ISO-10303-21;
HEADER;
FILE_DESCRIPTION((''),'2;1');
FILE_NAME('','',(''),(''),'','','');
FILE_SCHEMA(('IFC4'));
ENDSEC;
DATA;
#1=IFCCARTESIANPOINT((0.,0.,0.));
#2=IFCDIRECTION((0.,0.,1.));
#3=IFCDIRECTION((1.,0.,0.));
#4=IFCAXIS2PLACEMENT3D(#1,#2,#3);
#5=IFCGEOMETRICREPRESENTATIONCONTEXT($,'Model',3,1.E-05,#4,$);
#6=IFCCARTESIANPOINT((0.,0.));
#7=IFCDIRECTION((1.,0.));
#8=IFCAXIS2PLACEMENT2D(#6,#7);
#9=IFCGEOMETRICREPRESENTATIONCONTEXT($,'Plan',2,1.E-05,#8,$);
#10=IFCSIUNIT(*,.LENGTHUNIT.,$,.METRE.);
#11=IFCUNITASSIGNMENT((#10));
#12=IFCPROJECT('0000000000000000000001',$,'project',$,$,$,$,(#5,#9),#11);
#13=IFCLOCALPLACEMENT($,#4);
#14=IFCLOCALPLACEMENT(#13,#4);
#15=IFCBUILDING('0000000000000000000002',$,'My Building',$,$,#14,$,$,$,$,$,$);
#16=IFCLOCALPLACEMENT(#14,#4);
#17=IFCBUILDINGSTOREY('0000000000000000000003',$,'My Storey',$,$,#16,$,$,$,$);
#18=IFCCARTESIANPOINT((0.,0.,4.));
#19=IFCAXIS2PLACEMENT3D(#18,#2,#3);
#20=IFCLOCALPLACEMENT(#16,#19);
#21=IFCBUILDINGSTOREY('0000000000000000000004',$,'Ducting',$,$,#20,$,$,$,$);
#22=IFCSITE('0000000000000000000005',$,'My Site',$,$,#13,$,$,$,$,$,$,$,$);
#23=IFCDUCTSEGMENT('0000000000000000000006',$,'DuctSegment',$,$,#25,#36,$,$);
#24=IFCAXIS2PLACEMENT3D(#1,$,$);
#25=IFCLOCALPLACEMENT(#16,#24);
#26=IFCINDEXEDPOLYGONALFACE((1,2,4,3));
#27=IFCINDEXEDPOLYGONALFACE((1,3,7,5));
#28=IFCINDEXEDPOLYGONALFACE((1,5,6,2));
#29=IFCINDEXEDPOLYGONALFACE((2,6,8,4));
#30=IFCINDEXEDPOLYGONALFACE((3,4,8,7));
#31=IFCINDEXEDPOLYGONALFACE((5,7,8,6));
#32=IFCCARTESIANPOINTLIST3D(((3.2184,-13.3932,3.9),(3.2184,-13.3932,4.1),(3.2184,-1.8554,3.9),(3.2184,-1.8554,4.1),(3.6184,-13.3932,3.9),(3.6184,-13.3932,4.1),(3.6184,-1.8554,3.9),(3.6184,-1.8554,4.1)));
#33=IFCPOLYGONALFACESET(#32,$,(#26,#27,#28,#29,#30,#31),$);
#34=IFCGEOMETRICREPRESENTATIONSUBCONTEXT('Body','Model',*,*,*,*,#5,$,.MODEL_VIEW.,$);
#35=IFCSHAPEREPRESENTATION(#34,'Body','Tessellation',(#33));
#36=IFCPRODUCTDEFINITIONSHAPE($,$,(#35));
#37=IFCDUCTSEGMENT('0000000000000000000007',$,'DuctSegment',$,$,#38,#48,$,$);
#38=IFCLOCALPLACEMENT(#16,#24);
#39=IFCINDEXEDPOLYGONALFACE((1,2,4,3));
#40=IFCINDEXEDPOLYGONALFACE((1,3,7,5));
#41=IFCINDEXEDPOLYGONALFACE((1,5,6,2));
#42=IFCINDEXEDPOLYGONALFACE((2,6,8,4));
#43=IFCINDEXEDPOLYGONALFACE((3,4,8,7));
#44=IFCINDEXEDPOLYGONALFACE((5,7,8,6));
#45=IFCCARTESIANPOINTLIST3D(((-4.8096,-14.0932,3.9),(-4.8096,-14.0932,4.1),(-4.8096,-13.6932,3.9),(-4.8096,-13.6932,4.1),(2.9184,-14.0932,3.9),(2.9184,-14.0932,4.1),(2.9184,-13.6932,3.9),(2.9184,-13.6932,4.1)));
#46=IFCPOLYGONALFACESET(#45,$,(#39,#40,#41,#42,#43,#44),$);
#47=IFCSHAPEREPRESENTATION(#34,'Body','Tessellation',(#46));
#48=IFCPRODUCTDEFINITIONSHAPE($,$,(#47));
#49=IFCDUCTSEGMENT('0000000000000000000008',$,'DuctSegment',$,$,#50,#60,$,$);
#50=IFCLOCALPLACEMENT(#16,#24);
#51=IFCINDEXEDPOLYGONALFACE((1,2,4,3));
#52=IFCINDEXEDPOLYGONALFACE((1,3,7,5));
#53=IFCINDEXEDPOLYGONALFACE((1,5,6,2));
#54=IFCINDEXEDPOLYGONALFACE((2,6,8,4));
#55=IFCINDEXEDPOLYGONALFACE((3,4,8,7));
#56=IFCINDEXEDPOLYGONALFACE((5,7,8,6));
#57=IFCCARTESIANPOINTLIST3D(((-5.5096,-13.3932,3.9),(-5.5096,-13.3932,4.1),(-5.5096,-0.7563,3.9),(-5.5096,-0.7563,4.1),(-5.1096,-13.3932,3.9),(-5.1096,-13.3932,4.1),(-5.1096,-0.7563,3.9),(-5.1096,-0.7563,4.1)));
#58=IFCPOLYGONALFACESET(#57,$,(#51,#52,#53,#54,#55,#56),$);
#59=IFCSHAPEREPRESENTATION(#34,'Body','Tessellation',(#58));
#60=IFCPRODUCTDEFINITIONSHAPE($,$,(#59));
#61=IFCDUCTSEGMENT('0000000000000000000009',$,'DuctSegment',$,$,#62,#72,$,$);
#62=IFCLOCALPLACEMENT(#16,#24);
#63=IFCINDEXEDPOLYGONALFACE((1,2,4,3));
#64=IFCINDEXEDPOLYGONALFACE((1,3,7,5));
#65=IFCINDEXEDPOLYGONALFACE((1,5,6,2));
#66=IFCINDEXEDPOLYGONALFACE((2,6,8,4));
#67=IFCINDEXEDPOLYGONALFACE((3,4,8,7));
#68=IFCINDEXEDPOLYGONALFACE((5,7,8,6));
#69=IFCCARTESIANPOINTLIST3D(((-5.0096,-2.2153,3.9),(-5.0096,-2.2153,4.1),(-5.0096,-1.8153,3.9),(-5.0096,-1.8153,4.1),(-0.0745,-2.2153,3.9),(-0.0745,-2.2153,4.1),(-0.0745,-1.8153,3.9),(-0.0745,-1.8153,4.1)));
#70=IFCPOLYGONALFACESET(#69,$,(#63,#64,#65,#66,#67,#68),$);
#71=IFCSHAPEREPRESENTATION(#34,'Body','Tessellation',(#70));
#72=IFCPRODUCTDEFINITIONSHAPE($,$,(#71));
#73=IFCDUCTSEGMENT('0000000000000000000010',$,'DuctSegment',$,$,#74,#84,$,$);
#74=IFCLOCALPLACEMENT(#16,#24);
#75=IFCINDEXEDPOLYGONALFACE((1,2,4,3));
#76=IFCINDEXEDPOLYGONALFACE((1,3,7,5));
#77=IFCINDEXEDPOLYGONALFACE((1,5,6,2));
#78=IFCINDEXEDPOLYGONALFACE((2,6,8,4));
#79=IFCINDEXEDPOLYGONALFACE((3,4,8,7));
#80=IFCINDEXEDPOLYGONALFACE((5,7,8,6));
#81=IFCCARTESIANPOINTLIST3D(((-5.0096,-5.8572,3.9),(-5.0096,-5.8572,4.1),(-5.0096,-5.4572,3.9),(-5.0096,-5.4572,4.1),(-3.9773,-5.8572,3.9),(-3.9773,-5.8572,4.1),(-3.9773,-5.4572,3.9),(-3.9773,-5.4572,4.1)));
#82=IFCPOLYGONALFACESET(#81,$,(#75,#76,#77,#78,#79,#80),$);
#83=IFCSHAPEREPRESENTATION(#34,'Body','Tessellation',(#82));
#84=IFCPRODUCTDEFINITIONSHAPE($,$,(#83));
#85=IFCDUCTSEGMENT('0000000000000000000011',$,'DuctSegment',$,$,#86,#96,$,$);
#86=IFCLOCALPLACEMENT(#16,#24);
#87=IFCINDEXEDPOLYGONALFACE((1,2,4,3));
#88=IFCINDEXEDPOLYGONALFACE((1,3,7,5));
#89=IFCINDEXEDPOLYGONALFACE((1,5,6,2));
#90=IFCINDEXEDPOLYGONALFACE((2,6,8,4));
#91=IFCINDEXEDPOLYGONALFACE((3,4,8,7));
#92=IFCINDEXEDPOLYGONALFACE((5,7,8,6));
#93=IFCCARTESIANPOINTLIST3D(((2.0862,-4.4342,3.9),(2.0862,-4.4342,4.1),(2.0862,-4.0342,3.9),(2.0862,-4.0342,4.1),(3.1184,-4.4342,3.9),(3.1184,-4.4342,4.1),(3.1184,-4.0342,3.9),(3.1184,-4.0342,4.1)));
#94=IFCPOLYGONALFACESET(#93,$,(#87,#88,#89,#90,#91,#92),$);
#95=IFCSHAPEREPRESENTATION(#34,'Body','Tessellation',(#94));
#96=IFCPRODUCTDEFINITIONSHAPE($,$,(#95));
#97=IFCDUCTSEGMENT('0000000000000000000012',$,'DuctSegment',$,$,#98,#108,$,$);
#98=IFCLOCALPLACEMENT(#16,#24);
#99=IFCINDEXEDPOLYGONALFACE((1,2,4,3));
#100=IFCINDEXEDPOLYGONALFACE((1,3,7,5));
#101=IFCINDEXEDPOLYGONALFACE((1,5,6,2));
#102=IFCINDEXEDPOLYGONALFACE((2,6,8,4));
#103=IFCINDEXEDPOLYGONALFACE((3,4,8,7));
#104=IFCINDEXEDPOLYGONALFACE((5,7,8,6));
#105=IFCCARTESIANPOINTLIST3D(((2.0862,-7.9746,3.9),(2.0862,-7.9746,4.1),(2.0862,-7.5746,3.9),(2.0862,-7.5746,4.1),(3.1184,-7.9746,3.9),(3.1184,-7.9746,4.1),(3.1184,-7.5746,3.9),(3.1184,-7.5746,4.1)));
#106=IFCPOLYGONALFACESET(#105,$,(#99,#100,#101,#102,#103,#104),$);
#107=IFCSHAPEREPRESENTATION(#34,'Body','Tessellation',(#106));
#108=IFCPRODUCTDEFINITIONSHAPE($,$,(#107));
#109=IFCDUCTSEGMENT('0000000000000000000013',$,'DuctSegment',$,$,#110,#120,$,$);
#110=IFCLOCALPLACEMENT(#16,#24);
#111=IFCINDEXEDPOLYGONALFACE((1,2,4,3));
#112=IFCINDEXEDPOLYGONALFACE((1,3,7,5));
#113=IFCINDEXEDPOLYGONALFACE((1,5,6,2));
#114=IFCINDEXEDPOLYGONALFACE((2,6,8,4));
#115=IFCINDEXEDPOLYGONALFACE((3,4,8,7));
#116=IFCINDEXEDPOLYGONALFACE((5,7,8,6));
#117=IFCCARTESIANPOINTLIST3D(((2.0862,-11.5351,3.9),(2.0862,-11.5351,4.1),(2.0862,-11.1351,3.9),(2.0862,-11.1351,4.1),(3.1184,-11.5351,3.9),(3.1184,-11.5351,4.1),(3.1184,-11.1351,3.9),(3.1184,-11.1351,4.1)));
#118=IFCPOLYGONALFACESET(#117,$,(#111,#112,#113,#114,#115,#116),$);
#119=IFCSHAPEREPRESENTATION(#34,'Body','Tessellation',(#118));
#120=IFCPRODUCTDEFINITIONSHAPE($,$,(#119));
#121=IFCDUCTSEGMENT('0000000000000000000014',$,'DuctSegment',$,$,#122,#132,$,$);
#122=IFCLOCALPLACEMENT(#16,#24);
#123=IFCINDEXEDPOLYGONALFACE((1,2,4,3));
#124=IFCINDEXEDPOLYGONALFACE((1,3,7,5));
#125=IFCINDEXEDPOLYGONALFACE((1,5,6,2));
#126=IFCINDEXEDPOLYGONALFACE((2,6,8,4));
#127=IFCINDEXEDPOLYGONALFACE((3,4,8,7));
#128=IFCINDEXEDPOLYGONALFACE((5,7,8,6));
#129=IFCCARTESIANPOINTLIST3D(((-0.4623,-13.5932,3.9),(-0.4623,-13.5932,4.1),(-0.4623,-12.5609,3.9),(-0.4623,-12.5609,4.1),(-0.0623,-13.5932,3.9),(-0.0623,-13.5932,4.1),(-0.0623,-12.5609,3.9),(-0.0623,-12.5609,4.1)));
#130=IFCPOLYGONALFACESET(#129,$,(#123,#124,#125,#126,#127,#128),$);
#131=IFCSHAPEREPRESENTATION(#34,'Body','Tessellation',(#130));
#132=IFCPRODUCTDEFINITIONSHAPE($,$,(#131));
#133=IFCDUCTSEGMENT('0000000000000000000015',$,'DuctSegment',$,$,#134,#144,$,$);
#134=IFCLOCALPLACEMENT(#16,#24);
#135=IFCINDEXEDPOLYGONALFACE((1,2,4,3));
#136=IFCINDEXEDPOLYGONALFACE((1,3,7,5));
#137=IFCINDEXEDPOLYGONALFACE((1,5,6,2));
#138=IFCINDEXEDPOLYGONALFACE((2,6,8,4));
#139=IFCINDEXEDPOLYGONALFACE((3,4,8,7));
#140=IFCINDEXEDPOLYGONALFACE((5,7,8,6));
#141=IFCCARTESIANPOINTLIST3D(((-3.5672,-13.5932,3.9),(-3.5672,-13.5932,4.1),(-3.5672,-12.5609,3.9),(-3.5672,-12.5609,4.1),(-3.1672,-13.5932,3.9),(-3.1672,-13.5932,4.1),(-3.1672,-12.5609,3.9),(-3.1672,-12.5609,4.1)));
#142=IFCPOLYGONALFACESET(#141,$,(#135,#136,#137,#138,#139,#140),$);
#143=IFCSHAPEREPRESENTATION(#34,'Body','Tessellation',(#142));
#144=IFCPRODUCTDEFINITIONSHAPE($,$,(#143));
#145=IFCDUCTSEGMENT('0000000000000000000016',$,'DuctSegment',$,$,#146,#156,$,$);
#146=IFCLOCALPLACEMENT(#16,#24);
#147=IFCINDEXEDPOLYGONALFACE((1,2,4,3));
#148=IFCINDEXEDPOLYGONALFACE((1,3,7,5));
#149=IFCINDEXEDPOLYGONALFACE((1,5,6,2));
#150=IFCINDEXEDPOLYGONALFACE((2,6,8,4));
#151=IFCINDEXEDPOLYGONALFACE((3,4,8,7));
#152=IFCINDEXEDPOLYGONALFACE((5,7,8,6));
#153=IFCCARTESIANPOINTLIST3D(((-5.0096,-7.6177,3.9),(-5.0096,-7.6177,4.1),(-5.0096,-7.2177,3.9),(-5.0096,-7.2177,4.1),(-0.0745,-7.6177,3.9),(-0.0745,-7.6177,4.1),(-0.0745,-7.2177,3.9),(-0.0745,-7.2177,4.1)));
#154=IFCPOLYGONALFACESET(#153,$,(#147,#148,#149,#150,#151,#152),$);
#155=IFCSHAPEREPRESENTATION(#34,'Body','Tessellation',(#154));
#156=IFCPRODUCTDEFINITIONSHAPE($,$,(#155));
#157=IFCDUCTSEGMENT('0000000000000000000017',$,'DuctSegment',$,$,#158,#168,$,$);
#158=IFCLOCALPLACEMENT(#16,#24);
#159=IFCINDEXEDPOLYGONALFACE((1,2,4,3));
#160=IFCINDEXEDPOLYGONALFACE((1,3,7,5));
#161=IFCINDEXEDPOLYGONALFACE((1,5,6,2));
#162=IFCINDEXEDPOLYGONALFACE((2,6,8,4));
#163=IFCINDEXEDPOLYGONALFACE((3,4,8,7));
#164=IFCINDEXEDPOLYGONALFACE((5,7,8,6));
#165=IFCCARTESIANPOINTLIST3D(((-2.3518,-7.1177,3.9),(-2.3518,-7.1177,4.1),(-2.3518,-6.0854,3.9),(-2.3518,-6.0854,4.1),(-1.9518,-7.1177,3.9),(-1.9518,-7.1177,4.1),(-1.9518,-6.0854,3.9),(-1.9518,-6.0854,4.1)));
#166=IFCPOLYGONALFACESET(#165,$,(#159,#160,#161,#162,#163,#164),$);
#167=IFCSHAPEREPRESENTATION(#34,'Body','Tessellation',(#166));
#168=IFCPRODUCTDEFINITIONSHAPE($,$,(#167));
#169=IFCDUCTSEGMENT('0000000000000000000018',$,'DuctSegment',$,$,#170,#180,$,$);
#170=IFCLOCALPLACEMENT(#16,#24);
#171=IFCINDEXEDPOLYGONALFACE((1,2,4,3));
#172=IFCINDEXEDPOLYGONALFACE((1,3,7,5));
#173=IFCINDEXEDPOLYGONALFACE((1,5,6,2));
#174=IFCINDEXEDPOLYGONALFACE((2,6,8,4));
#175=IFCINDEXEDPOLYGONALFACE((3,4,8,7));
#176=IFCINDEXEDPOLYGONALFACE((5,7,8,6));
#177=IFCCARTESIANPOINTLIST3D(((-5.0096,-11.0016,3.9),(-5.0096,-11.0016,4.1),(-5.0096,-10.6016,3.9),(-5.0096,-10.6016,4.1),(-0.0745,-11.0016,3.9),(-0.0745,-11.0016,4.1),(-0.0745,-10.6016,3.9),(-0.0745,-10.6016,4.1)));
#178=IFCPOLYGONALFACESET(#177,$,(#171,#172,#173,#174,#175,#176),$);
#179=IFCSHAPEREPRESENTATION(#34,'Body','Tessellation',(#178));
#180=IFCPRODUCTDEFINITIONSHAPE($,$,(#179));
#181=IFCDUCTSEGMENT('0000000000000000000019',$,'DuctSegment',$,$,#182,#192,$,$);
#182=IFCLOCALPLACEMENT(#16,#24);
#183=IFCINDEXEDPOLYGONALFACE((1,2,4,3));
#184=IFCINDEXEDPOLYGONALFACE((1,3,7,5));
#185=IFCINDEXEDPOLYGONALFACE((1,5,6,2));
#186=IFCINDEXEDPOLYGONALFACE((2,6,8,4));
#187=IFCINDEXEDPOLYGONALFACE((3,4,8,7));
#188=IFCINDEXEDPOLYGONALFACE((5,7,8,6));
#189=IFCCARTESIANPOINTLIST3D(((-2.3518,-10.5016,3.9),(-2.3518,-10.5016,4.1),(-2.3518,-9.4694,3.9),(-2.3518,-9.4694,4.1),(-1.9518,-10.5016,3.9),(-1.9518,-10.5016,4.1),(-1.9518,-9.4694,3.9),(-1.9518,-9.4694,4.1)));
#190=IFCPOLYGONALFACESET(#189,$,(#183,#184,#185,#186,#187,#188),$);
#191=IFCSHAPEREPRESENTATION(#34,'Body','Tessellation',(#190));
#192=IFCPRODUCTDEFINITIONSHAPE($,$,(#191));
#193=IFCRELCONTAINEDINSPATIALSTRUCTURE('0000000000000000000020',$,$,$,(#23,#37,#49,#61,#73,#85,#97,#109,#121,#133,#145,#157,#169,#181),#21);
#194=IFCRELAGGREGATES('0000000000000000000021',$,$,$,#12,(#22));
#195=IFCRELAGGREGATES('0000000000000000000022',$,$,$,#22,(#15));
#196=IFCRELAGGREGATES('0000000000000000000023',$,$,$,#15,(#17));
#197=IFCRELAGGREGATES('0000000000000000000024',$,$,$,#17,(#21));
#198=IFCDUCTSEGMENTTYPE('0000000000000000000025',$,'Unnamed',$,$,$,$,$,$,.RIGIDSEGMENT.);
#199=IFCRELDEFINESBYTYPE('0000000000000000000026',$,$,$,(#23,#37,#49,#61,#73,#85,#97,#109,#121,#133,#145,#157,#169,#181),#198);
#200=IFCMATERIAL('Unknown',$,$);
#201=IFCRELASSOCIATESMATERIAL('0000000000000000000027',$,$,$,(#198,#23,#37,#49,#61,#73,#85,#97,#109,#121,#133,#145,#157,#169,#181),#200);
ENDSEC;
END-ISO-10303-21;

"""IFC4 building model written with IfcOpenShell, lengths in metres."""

from ifc_helpers import new_model, si_unit, frame, origin_with_axes, origin_2d_with_axis, place, context, subcontext, project, spatial, rectangle, extrude, material, material_profile, profile_set, profile_usage, type_object, element, save


model = new_model("IFC4")

# Units and contexts
model_context = context("Model", 3, precision=1e-05, world=origin_with_axes())
plan_context = context("Plan", 2, precision=1e-05, world=origin_2d_with_axis())
body_context = subcontext(model_context, "Body", "Model", "MODEL_VIEW")
ifc_project = project(units=[si_unit("LENGTHUNIT", "METRE")], contexts=[model_context, plan_context])

# Site, building, storeys
site_placement = place(None, origin_with_axes())
site = spatial("IfcSite", under=ifc_project, at=site_placement, Name="My Site")
building_placement = place(site_placement, origin_with_axes())
building = spatial("IfcBuilding", under=site, at=building_placement, Name="My Building")
storey_1_placement = place(building_placement, origin_with_axes())
storey_1 = spatial("IfcBuildingStorey", under=building, at=storey_1_placement, Name="My Storey")
storey_2_placement = place(storey_1_placement, frame((0.0, 0.0, 4.0), z_axis=(0.0, 0.0, 1.0), x_axis=(1.0, 0.0, 0.0)))
storey_2 = spatial("IfcBuildingStorey", under=storey_1, at=storey_2_placement, Name="Ducting")

# Duct segments
ifc_material = material(Name="Unknown")
ifc_material_profile_1 = material_profile(ifc_material, rectangle(XDim=0.4, YDim=0.2))
ifc_profile_set_1 = profile_set([ifc_material_profile_1])
ifc_profile_usage_1 = profile_usage(ifc_profile_set_1, cardinal=5)
duct_segment_type = type_object("IfcDuctSegmentType", Name="Unnamed", PredefinedType="RIGIDSEGMENT", material=ifc_profile_set_1)
duct_segment_1_placement = place(storey_2_placement, frame((3.4184, -1.8554, 0.0), z_axis=(0.0, -1.0, 0.0), x_axis=(1.0, 0.0, 0.0)))
element("IfcDuctSegment", 1, at=duct_segment_1_placement, inside=storey_2, type_object=duct_segment_type, material=ifc_profile_usage_1, Name="DuctSegment", context=body_context, shape_type="SweptSolid", body=[
    extrude(rectangle(XDim=0.4, YDim=0.2), origin_with_axes(), (0.0, 0.0, 1.0), 11.5378),
])
ifc_profile_usage_2 = profile_usage(ifc_profile_set_1, cardinal=5)
duct_segment_2_placement = place(storey_2_placement, frame((2.9184, -13.8932, 0.0), z_axis=(-1.0, 0.0, 0.0), x_axis=(0.0, -1.0, 0.0)))
element("IfcDuctSegment", 2, at=duct_segment_2_placement, inside=storey_2, type_object=duct_segment_type, material=ifc_profile_usage_2, Name="DuctSegment", context=body_context, shape_type="SweptSolid", body=[
    extrude(rectangle(XDim=0.4, YDim=0.2), origin_with_axes(), (0.0, 0.0, 1.0), 7.728),
])
ifc_profile_usage_3 = profile_usage(ifc_profile_set_1, cardinal=5)
duct_segment_3_placement = place(storey_2_placement, frame((-5.3096, -13.3932, 0.0), z_axis=(0.0, 1.0, 0.0), x_axis=(-1.0, 0.0, 0.0)))
element("IfcDuctSegment", 3, at=duct_segment_3_placement, inside=storey_2, type_object=duct_segment_type, material=ifc_profile_usage_3, Name="DuctSegment", context=body_context, shape_type="SweptSolid", body=[
    extrude(rectangle(XDim=0.4, YDim=0.2), origin_with_axes(), (0.0, 0.0, 1.0), 12.6369),
])
ifc_profile_usage_4 = profile_usage(ifc_profile_set_1, cardinal=5)
duct_segment_4_placement = place(storey_2_placement, frame((-5.0096, -2.0153, 0.0), z_axis=(1.0, 0.0, 0.0), x_axis=(0.0, 1.0, 0.0)))
element("IfcDuctSegment", 4, at=duct_segment_4_placement, inside=storey_2, type_object=duct_segment_type, material=ifc_profile_usage_4, Name="DuctSegment", context=body_context, shape_type="SweptSolid", body=[
    extrude(rectangle(XDim=0.4, YDim=0.2), origin_with_axes(), (0.0, 0.0, 1.0), 4.9351),
])
ifc_profile_usage_5 = profile_usage(ifc_profile_set_1, cardinal=5)
duct_segment_5_placement = place(storey_2_placement, frame((-5.0096, -5.6572, 0.0), z_axis=(1.0, 0.0, 0.0), x_axis=(0.0, 1.0, 0.0)))
element("IfcDuctSegment", 5, at=duct_segment_5_placement, inside=storey_2, type_object=duct_segment_type, material=ifc_profile_usage_5, Name="DuctSegment", context=body_context, shape_type="SweptSolid", body=[
    extrude(rectangle(XDim=0.4, YDim=0.2), origin_with_axes(), (0.0, 0.0, 1.0), 1.0323),
])
ifc_profile_usage_6 = profile_usage(ifc_profile_set_1, cardinal=5)
duct_segment_6_placement = place(storey_2_placement, frame((3.1184, -4.2342, 0.0), z_axis=(-1.0, 0.0, 0.0), x_axis=(0.0, -1.0, 0.0)))
element("IfcDuctSegment", 6, at=duct_segment_6_placement, inside=storey_2, type_object=duct_segment_type, material=ifc_profile_usage_6, Name="DuctSegment", context=body_context, shape_type="SweptSolid", body=[
    extrude(rectangle(XDim=0.4, YDim=0.2), origin_with_axes(), (0.0, 0.0, 1.0), 1.0323),
])
ifc_profile_usage_7 = profile_usage(ifc_profile_set_1, cardinal=5)
duct_segment_7_placement = place(storey_2_placement, frame((3.1184, -7.7746, 0.0), z_axis=(-1.0, 0.0, 0.0), x_axis=(0.0, -1.0, 0.0)))
element("IfcDuctSegment", 7, at=duct_segment_7_placement, inside=storey_2, type_object=duct_segment_type, material=ifc_profile_usage_7, Name="DuctSegment", context=body_context, shape_type="SweptSolid", body=[
    extrude(rectangle(XDim=0.4, YDim=0.2), origin_with_axes(), (0.0, 0.0, 1.0), 1.0323),
])
ifc_profile_usage_8 = profile_usage(ifc_profile_set_1, cardinal=5)
duct_segment_8_placement = place(storey_2_placement, frame((3.1184, -11.3351, 0.0), z_axis=(-1.0, 0.0, 0.0), x_axis=(0.0, -1.0, 0.0)))
element("IfcDuctSegment", 8, at=duct_segment_8_placement, inside=storey_2, type_object=duct_segment_type, material=ifc_profile_usage_8, Name="DuctSegment", context=body_context, shape_type="SweptSolid", body=[
    extrude(rectangle(XDim=0.4, YDim=0.2), origin_with_axes(), (0.0, 0.0, 1.0), 1.0323),
])
ifc_profile_usage_9 = profile_usage(ifc_profile_set_1, cardinal=5)
duct_segment_9_placement = place(storey_2_placement, frame((-0.2623, -13.5932, 0.0), z_axis=(0.0, 1.0, 0.0), x_axis=(-1.0, 0.0, 0.0)))
element("IfcDuctSegment", 9, at=duct_segment_9_placement, inside=storey_2, type_object=duct_segment_type, material=ifc_profile_usage_9, Name="DuctSegment", context=body_context, shape_type="SweptSolid", body=[
    extrude(rectangle(XDim=0.4, YDim=0.2), origin_with_axes(), (0.0, 0.0, 1.0), 1.0323),
])
ifc_profile_usage_10 = profile_usage(ifc_profile_set_1, cardinal=5)
duct_segment_10_placement = place(storey_2_placement, frame((-3.3672, -13.5932, 0.0), z_axis=(0.0, 1.0, 0.0), x_axis=(-1.0, 0.0, 0.0)))
element("IfcDuctSegment", 10, at=duct_segment_10_placement, inside=storey_2, type_object=duct_segment_type, material=ifc_profile_usage_10, Name="DuctSegment", context=body_context, shape_type="SweptSolid", body=[
    extrude(rectangle(XDim=0.4, YDim=0.2), origin_with_axes(), (0.0, 0.0, 1.0), 1.0323),
])
ifc_profile_usage_11 = profile_usage(ifc_profile_set_1, cardinal=5)
duct_segment_11_placement = place(storey_2_placement, frame((-5.0096, -7.4177, 0.0), z_axis=(1.0, 0.0, 0.0), x_axis=(0.0, 1.0, 0.0)))
element("IfcDuctSegment", 11, at=duct_segment_11_placement, inside=storey_2, type_object=duct_segment_type, material=ifc_profile_usage_11, Name="DuctSegment", context=body_context, shape_type="SweptSolid", body=[
    extrude(rectangle(XDim=0.4, YDim=0.2), origin_with_axes(), (0.0, 0.0, 1.0), 4.9351),
])
ifc_profile_usage_12 = profile_usage(ifc_profile_set_1, cardinal=5)
duct_segment_12_placement = place(storey_2_placement, frame((-2.1518, -7.1177, 0.0), z_axis=(0.0, 1.0, 0.0), x_axis=(-1.0, 0.0, 0.0)))
element("IfcDuctSegment", 12, at=duct_segment_12_placement, inside=storey_2, type_object=duct_segment_type, material=ifc_profile_usage_12, Name="DuctSegment", context=body_context, shape_type="SweptSolid", body=[
    extrude(rectangle(XDim=0.4, YDim=0.2), origin_with_axes(), (0.0, 0.0, 1.0), 1.0323),
])
ifc_profile_usage_13 = profile_usage(ifc_profile_set_1, cardinal=5)
duct_segment_13_placement = place(storey_2_placement, frame((-5.0096, -10.8016, 0.0), z_axis=(1.0, 0.0, 0.0), x_axis=(0.0, 1.0, 0.0)))
element("IfcDuctSegment", 13, at=duct_segment_13_placement, inside=storey_2, type_object=duct_segment_type, material=ifc_profile_usage_13, Name="DuctSegment", context=body_context, shape_type="SweptSolid", body=[
    extrude(rectangle(XDim=0.4, YDim=0.2), origin_with_axes(), (0.0, 0.0, 1.0), 4.9351),
])
ifc_profile_usage_14 = profile_usage(ifc_profile_set_1, cardinal=5)
duct_segment_14_placement = place(storey_2_placement, frame((-2.1518, -10.5016, 0.0), z_axis=(0.0, 1.0, 0.0), x_axis=(-1.0, 0.0, 0.0)))
element("IfcDuctSegment", 14, at=duct_segment_14_placement, inside=storey_2, type_object=duct_segment_type, material=ifc_profile_usage_14, Name="DuctSegment", context=body_context, shape_type="SweptSolid", body=[
    extrude(rectangle(XDim=0.4, YDim=0.2), origin_with_axes(), (0.0, 0.0, 1.0), 1.0323),
])

save(model, "model.ifc")
